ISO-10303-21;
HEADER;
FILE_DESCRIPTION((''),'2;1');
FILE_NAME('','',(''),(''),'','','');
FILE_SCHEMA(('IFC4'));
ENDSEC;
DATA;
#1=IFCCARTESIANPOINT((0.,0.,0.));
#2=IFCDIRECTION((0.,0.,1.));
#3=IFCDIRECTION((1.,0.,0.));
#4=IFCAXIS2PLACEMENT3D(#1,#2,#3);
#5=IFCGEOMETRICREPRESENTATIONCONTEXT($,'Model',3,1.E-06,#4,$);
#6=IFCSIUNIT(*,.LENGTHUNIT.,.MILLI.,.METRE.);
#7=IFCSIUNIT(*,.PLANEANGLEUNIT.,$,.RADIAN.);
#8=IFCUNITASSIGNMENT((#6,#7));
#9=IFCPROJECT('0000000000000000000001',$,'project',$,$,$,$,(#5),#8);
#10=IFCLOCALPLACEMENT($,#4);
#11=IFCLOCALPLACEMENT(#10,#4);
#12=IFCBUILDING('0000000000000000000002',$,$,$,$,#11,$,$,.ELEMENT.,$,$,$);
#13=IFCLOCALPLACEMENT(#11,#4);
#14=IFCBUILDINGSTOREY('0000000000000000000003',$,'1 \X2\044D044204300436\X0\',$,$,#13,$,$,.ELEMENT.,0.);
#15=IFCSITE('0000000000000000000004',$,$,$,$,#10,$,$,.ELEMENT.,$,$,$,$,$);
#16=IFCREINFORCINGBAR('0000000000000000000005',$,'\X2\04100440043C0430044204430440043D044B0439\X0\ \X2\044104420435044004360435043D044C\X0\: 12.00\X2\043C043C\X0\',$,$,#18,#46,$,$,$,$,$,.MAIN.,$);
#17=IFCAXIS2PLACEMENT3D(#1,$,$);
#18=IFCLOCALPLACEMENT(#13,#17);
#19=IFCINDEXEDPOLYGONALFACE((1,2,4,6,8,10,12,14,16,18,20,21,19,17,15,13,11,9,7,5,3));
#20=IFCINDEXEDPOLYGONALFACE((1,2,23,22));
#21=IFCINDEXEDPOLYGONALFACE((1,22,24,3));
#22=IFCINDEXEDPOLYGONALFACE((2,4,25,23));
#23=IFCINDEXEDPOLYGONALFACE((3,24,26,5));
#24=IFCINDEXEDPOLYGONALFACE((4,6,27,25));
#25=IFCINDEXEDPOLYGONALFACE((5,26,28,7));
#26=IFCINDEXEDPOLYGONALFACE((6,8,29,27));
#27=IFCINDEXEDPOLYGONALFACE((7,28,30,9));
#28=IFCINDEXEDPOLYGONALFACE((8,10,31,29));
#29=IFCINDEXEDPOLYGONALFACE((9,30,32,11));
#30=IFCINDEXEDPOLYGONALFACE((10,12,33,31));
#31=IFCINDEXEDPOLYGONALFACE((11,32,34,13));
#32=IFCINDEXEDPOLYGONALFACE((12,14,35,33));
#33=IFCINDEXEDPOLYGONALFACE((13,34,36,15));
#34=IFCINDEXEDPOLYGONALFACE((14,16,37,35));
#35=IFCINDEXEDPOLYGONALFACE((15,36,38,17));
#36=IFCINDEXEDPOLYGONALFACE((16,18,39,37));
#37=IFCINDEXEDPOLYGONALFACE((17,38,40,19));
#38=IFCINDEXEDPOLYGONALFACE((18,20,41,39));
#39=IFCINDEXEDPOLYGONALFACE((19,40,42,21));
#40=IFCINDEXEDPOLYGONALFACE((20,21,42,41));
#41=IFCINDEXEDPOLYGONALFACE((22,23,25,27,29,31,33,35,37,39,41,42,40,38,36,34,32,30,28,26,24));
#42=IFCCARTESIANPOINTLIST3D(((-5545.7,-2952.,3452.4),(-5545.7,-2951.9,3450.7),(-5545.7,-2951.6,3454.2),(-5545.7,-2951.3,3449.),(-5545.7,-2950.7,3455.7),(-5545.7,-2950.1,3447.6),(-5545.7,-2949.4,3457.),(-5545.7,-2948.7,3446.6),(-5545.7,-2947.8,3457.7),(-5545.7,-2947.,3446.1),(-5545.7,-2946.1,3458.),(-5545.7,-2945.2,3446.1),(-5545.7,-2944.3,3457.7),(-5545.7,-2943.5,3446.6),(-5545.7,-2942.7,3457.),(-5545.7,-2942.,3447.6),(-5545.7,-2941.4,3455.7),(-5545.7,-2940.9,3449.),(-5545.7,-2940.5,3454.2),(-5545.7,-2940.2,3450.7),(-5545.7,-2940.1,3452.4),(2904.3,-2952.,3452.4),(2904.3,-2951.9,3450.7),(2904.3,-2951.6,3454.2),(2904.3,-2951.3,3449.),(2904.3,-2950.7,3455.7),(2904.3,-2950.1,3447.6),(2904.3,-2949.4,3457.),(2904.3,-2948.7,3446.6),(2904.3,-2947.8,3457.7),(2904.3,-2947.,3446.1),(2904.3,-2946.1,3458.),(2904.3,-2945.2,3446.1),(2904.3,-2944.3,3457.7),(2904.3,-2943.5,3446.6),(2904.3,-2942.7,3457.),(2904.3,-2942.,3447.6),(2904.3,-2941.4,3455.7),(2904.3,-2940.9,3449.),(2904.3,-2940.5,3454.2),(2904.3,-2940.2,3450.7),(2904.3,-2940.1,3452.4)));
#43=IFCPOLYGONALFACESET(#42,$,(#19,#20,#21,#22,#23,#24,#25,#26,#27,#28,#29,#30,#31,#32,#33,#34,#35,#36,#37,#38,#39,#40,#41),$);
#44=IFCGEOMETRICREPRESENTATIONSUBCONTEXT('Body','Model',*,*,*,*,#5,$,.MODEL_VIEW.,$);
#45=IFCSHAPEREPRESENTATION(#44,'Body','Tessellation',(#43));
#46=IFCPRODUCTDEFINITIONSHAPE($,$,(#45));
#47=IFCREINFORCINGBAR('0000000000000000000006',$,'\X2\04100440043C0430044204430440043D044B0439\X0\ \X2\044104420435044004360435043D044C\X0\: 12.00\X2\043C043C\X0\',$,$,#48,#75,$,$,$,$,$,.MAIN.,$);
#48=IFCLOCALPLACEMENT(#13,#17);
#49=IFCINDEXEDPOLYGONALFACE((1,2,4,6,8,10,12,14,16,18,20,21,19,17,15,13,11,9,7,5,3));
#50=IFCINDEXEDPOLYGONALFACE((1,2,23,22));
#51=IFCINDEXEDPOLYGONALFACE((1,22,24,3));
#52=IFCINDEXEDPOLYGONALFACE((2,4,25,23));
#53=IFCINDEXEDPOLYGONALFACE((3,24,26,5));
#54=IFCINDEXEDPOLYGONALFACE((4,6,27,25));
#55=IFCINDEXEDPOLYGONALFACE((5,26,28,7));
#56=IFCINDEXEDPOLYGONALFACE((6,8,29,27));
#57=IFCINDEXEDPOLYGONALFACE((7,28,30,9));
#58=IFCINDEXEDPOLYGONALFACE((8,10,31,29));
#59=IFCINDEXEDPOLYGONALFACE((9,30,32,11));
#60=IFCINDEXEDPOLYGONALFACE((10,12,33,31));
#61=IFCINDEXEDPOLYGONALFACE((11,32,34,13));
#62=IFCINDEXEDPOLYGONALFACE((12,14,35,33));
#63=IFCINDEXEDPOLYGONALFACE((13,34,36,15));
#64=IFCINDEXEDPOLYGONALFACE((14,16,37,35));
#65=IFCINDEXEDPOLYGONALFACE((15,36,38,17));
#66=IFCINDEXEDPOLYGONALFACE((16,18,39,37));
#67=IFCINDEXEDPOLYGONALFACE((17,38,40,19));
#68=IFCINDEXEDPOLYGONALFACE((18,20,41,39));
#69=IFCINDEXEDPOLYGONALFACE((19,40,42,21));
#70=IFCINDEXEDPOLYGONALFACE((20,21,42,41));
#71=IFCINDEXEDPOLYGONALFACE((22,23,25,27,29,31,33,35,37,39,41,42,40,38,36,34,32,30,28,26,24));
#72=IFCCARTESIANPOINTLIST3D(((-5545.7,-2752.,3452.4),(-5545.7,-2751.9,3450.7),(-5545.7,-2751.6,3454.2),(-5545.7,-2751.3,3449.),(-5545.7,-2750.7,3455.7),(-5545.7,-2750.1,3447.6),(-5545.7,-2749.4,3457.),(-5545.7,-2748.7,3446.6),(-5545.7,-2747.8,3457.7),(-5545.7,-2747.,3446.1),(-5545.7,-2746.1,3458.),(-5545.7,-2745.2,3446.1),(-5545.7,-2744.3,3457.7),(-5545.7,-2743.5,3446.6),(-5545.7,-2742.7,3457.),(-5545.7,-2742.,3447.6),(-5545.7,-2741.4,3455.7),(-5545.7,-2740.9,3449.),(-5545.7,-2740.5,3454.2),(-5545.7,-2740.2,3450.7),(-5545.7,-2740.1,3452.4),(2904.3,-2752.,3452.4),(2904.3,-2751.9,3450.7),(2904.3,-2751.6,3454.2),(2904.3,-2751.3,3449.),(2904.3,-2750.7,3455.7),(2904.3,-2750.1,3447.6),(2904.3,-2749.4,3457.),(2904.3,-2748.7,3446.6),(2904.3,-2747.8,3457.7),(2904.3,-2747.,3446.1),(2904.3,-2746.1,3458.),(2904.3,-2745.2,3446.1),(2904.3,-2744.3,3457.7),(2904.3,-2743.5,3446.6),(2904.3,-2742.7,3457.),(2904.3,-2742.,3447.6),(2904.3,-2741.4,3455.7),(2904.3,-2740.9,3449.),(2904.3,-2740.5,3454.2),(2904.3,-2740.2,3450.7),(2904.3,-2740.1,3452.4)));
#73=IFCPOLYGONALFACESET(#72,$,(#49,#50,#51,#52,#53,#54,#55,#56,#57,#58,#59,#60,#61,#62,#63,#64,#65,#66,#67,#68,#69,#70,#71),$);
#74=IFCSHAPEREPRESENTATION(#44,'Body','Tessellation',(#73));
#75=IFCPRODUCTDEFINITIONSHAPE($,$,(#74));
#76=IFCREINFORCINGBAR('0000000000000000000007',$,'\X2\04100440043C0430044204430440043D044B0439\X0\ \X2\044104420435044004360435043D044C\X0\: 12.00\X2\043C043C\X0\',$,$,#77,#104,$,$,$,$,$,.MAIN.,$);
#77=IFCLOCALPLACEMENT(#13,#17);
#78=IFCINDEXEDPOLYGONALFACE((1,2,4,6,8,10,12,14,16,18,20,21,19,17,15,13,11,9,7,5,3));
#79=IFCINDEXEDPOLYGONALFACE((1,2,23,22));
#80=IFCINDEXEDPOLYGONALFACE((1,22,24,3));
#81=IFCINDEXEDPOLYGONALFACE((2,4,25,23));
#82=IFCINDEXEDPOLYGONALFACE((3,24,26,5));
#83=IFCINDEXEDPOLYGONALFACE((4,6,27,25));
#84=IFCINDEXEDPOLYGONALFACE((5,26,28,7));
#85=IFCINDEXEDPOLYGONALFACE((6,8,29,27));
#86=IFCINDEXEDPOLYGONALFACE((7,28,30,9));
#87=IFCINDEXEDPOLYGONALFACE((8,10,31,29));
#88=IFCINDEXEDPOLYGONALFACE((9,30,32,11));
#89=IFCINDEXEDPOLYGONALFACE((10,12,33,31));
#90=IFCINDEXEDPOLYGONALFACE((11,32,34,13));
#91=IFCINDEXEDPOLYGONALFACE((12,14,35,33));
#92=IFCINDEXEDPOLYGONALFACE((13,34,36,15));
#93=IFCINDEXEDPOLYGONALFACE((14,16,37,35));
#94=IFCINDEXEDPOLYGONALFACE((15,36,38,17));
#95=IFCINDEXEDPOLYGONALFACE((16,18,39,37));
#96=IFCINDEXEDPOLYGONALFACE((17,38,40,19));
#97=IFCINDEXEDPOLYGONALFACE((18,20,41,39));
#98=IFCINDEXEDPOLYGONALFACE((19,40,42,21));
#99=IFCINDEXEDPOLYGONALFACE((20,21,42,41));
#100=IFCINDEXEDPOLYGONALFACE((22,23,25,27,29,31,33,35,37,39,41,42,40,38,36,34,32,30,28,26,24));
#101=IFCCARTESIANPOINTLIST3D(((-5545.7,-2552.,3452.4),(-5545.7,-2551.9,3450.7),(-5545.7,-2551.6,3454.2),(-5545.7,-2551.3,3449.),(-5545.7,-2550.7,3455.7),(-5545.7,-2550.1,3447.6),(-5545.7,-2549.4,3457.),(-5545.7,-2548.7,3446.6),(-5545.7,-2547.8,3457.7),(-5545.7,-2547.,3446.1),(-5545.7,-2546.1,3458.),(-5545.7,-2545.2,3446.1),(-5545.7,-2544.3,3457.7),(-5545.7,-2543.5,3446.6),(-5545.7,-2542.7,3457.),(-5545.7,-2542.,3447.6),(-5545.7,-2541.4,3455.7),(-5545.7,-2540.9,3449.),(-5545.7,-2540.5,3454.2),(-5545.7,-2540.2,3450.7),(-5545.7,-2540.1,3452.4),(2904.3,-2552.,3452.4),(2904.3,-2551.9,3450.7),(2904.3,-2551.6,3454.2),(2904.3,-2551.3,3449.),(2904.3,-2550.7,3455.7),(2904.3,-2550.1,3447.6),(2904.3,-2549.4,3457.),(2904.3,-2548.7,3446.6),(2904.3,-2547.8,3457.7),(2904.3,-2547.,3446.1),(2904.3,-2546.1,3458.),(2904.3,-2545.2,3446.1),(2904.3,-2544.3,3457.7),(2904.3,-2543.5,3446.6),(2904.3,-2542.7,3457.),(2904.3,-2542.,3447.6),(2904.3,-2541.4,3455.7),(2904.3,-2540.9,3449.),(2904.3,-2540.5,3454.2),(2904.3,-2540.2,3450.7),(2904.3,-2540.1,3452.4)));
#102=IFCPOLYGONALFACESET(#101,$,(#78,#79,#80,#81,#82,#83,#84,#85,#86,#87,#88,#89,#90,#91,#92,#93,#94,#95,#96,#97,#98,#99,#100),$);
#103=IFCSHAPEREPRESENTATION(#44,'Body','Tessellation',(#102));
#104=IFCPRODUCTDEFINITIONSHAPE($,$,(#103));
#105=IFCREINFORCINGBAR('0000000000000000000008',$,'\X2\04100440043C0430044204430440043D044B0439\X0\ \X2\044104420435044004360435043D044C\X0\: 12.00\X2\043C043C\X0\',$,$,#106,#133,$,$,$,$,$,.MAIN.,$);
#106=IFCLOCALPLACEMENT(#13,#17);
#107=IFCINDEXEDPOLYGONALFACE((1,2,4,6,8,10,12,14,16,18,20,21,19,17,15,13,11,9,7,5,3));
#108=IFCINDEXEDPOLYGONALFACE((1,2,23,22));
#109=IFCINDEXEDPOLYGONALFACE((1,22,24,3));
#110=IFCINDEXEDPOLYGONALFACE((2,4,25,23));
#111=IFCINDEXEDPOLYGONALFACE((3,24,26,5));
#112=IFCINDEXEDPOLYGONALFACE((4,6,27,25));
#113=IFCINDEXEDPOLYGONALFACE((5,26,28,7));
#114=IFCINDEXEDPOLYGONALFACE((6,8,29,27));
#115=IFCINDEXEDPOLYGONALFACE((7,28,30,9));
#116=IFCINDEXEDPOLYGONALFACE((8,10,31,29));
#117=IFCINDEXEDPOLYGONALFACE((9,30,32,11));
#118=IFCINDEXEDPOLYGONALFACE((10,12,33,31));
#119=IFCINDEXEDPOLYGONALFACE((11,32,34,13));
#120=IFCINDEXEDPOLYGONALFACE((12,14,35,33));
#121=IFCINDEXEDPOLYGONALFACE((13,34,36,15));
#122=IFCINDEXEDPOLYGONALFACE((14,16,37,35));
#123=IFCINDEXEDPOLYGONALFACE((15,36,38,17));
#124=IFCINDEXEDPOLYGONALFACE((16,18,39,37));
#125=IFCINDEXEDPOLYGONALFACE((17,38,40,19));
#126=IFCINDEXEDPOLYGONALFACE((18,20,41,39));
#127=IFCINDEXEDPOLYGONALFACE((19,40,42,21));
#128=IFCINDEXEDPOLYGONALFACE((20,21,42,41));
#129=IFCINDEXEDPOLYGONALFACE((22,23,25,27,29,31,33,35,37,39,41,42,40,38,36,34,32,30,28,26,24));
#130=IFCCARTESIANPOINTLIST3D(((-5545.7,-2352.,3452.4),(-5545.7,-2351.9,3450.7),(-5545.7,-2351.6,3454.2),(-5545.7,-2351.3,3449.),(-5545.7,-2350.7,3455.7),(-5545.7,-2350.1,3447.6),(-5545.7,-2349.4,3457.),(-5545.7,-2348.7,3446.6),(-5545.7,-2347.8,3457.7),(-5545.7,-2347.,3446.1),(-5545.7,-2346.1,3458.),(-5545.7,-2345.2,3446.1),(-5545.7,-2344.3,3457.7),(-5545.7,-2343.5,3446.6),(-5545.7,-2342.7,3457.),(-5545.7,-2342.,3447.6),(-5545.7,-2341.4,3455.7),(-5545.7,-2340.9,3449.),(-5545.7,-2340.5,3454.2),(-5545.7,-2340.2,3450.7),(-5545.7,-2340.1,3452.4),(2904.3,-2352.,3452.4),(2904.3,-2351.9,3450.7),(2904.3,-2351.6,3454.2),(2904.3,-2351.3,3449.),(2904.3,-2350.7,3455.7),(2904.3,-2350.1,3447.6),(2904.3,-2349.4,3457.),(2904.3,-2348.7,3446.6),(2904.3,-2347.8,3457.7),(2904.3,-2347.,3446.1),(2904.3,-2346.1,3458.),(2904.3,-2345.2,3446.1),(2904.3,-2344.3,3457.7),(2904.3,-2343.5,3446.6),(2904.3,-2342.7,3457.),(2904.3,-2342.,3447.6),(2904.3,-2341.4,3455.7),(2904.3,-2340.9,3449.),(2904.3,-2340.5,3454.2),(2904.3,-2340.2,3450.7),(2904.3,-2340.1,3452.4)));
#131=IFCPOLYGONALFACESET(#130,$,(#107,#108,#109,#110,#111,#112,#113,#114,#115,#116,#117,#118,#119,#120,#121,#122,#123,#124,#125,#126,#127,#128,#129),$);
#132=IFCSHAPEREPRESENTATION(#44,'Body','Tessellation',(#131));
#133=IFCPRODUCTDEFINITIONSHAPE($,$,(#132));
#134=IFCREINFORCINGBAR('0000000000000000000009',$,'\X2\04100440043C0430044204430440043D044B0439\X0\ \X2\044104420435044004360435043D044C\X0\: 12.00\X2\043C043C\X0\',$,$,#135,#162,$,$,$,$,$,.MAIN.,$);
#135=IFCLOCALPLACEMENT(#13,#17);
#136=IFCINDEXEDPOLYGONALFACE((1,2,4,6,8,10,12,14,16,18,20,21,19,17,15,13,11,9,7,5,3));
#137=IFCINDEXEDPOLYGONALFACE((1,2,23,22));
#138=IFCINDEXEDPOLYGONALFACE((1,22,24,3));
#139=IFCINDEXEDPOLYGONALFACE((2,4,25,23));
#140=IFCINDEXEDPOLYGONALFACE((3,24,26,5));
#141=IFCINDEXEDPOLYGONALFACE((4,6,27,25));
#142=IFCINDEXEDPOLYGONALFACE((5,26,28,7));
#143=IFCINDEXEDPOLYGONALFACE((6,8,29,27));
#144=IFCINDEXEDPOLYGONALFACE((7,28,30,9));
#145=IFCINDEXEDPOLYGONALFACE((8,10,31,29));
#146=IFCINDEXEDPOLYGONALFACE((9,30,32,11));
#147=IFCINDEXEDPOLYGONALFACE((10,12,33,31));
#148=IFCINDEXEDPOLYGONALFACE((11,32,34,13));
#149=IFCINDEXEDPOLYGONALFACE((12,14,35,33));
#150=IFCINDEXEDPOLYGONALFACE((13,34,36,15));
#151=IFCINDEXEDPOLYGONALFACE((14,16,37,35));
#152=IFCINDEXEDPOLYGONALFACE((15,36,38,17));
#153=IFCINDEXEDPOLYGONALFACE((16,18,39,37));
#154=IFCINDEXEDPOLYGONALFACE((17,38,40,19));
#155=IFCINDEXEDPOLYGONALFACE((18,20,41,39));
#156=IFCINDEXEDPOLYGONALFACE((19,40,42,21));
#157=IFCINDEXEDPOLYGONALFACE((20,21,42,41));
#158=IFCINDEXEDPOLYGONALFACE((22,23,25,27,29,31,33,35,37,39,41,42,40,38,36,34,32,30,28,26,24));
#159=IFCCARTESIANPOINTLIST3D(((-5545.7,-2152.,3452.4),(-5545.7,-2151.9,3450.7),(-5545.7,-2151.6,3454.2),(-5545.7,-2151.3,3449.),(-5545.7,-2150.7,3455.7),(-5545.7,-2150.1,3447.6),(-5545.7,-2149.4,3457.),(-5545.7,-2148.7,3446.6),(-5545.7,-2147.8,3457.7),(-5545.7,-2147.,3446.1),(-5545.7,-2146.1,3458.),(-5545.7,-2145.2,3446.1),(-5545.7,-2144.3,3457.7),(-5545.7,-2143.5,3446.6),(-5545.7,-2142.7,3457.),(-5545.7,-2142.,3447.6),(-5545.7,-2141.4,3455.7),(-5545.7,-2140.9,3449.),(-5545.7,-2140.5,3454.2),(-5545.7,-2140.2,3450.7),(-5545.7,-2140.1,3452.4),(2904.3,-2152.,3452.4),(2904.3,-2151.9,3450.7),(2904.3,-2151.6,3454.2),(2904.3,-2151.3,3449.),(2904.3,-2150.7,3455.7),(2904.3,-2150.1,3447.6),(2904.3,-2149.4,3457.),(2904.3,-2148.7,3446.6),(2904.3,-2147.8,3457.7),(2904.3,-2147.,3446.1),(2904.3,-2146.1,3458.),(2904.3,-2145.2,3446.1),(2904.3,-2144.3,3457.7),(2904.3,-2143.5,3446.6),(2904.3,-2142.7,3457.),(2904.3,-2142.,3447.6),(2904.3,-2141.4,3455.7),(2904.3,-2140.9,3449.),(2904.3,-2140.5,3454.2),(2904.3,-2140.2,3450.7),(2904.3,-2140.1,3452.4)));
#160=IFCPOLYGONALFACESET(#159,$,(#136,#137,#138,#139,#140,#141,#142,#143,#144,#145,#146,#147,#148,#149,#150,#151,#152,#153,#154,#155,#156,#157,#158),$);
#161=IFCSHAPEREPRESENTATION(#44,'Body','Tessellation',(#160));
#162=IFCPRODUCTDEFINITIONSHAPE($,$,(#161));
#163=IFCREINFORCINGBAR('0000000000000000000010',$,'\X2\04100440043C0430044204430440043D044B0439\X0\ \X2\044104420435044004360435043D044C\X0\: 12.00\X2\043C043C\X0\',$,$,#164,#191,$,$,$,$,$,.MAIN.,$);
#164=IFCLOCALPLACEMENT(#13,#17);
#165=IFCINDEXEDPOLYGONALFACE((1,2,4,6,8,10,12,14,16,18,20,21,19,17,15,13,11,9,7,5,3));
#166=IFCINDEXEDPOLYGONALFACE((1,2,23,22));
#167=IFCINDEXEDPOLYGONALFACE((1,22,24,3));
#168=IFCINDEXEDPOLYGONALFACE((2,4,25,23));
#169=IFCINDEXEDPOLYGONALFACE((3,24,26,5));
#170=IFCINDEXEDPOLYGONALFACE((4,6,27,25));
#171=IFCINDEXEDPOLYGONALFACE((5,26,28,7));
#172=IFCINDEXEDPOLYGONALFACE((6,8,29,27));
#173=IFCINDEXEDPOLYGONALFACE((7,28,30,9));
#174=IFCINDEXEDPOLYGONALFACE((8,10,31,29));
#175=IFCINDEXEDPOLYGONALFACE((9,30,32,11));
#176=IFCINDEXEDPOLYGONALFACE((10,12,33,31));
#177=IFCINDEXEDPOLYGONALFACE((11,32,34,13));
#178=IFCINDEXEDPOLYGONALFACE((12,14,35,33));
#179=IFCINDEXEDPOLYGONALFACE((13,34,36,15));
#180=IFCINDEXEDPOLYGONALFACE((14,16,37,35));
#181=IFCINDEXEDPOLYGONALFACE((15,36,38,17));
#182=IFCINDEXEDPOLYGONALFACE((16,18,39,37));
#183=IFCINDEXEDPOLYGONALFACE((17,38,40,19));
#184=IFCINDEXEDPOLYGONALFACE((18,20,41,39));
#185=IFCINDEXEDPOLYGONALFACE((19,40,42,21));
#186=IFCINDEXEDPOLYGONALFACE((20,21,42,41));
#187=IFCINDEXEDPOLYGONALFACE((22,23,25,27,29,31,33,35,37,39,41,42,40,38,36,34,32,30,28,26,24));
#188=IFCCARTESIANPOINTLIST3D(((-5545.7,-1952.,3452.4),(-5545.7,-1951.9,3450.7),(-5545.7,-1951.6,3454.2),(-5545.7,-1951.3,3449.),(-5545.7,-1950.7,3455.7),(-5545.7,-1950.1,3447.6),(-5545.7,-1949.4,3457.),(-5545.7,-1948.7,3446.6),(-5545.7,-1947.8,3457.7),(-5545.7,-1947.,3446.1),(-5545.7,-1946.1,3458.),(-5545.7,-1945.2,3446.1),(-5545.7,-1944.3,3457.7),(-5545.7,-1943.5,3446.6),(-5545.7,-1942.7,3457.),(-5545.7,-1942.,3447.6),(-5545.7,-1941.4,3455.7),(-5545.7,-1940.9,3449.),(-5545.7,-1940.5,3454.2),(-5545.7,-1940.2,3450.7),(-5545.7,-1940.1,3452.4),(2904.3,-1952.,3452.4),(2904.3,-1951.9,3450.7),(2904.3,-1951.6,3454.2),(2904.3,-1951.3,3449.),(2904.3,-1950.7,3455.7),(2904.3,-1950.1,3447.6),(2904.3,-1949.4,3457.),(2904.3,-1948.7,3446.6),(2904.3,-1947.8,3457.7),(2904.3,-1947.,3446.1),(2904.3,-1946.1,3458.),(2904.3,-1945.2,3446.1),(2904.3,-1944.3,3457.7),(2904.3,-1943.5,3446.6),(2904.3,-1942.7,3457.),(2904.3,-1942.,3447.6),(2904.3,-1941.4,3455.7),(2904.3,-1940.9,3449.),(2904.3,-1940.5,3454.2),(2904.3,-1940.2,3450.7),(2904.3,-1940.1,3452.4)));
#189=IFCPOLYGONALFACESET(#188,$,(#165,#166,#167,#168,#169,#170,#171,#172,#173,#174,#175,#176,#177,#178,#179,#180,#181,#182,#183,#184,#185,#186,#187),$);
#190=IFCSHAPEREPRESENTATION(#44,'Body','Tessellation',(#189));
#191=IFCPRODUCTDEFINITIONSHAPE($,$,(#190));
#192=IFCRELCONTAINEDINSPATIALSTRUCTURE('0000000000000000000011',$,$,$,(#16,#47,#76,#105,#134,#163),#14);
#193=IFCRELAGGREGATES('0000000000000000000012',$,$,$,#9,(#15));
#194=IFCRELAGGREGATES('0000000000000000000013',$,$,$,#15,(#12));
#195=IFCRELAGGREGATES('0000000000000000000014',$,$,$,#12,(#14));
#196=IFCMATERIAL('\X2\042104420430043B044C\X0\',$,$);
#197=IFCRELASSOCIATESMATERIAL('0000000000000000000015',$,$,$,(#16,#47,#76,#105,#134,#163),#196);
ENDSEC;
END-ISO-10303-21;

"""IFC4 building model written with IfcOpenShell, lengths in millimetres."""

from ifc_helpers import new_model, entity, si_unit, origin_with_axes, place, context, subcontext, project, spatial, source, transform, mapped, material, element, save


model = new_model("IFC4")

# Units and contexts
model_context = context("Model", 3, precision=1e-06, world=origin_with_axes())
body_context = subcontext(model_context, "Body", "Model", "MODEL_VIEW")
ifc_project = project(units=[si_unit("LENGTHUNIT", "METRE", prefix="MILLI"), si_unit("PLANEANGLEUNIT", "RADIAN")], contexts=[model_context])

# Site, building, storey
site_placement = place(None, origin_with_axes())
site = spatial("IfcSite", under=ifc_project, at=site_placement, CompositionType="ELEMENT")
building_placement = place(site_placement, origin_with_axes())
building = spatial("IfcBuilding", under=site, at=building_placement, CompositionType="ELEMENT")
storey_placement = place(building_placement, origin_with_axes())
storey = spatial("IfcBuildingStorey", under=building, at=storey_placement, Name="1 этаж", CompositionType="ELEMENT", Elevation=0.0)

# Reinforcing bars
ifc_material_1 = material(Name="Сталь")
shared_shape_1 = source(origin_with_axes(), body_context, "Body", "AdvancedSweptSolid", [
    entity("IfcSweptDiskSolid", entity("IfcIndexedPolyCurve", entity("IfcCartesianPointList3D", [[0.0, 0.0, 0.0], [8450.0, 0.0, 0.0]]), [entity("IfcLineIndex", [1, 2])]), 6.0),
])
reinforcing_bar_1_placement = place(storey_placement, origin_with_axes())
element("IfcReinforcingBar", 1, at=reinforcing_bar_1_placement, inside=storey, material=ifc_material_1, Name="Арматурный стержень: 12.00мм", PredefinedType="MAIN", context=body_context, shape_type="MappedRepresentation", body=[
    mapped(shared_shape_1, transform((-5545.7, -2946.1, 3452.0), x_axis=(1.0, 0.0, 0.0), y_axis=(0.0, 1.0, 0.0), z_axis=(0.0, 0.0, 1.0), scale=1.0)),
])
reinforcing_bar_2_placement = place(storey_placement, origin_with_axes())
element("IfcReinforcingBar", 2, at=reinforcing_bar_2_placement, inside=storey, material=ifc_material_1, Name="Арматурный стержень: 12.00мм", PredefinedType="MAIN", context=body_context, shape_type="MappedRepresentation", body=[
    mapped(shared_shape_1, transform((-5545.7, -2746.1, 3452.0), x_axis=(1.0, 0.0, 0.0), y_axis=(0.0, 1.0, 0.0), z_axis=(0.0, 0.0, 1.0), scale=1.0)),
])
reinforcing_bar_3_placement = place(storey_placement, origin_with_axes())
element("IfcReinforcingBar", 3, at=reinforcing_bar_3_placement, inside=storey, material=ifc_material_1, Name="Арматурный стержень: 12.00мм", PredefinedType="MAIN", context=body_context, shape_type="MappedRepresentation", body=[
    mapped(shared_shape_1, transform((-5545.7, -2546.1, 3452.0), x_axis=(1.0, 0.0, 0.0), y_axis=(0.0, 1.0, 0.0), z_axis=(0.0, 0.0, 1.0), scale=1.0)),
])
reinforcing_bar_4_placement = place(storey_placement, origin_with_axes())
element("IfcReinforcingBar", 4, at=reinforcing_bar_4_placement, inside=storey, material=ifc_material_1, Name="Арматурный стержень: 12.00мм", PredefinedType="MAIN", context=body_context, shape_type="MappedRepresentation", body=[
    mapped(shared_shape_1, transform((-5545.7, -2346.1, 3452.0), x_axis=(1.0, 0.0, 0.0), y_axis=(0.0, 1.0, 0.0), z_axis=(0.0, 0.0, 1.0), scale=1.0)),
])
reinforcing_bar_5_placement = place(storey_placement, origin_with_axes())
element("IfcReinforcingBar", 5, at=reinforcing_bar_5_placement, inside=storey, material=ifc_material_1, Name="Арматурный стержень: 12.00мм", PredefinedType="MAIN", context=body_context, shape_type="MappedRepresentation", body=[
    mapped(shared_shape_1, transform((-5545.7, -2146.1, 3452.0), x_axis=(1.0, 0.0, 0.0), y_axis=(0.0, 1.0, 0.0), z_axis=(0.0, 0.0, 1.0), scale=1.0)),
])
reinforcing_bar_6_placement = place(storey_placement, origin_with_axes())
element("IfcReinforcingBar", 6, at=reinforcing_bar_6_placement, inside=storey, material=ifc_material_1, Name="Арматурный стержень: 12.00мм", PredefinedType="MAIN", context=body_context, shape_type="MappedRepresentation", body=[
    mapped(shared_shape_1, transform((-5545.7, -1946.1, 3452.0), x_axis=(1.0, 0.0, 0.0), y_axis=(0.0, 1.0, 0.0), z_axis=(0.0, 0.0, 1.0), scale=1.0)),
])

save(model, "model.ifc")
